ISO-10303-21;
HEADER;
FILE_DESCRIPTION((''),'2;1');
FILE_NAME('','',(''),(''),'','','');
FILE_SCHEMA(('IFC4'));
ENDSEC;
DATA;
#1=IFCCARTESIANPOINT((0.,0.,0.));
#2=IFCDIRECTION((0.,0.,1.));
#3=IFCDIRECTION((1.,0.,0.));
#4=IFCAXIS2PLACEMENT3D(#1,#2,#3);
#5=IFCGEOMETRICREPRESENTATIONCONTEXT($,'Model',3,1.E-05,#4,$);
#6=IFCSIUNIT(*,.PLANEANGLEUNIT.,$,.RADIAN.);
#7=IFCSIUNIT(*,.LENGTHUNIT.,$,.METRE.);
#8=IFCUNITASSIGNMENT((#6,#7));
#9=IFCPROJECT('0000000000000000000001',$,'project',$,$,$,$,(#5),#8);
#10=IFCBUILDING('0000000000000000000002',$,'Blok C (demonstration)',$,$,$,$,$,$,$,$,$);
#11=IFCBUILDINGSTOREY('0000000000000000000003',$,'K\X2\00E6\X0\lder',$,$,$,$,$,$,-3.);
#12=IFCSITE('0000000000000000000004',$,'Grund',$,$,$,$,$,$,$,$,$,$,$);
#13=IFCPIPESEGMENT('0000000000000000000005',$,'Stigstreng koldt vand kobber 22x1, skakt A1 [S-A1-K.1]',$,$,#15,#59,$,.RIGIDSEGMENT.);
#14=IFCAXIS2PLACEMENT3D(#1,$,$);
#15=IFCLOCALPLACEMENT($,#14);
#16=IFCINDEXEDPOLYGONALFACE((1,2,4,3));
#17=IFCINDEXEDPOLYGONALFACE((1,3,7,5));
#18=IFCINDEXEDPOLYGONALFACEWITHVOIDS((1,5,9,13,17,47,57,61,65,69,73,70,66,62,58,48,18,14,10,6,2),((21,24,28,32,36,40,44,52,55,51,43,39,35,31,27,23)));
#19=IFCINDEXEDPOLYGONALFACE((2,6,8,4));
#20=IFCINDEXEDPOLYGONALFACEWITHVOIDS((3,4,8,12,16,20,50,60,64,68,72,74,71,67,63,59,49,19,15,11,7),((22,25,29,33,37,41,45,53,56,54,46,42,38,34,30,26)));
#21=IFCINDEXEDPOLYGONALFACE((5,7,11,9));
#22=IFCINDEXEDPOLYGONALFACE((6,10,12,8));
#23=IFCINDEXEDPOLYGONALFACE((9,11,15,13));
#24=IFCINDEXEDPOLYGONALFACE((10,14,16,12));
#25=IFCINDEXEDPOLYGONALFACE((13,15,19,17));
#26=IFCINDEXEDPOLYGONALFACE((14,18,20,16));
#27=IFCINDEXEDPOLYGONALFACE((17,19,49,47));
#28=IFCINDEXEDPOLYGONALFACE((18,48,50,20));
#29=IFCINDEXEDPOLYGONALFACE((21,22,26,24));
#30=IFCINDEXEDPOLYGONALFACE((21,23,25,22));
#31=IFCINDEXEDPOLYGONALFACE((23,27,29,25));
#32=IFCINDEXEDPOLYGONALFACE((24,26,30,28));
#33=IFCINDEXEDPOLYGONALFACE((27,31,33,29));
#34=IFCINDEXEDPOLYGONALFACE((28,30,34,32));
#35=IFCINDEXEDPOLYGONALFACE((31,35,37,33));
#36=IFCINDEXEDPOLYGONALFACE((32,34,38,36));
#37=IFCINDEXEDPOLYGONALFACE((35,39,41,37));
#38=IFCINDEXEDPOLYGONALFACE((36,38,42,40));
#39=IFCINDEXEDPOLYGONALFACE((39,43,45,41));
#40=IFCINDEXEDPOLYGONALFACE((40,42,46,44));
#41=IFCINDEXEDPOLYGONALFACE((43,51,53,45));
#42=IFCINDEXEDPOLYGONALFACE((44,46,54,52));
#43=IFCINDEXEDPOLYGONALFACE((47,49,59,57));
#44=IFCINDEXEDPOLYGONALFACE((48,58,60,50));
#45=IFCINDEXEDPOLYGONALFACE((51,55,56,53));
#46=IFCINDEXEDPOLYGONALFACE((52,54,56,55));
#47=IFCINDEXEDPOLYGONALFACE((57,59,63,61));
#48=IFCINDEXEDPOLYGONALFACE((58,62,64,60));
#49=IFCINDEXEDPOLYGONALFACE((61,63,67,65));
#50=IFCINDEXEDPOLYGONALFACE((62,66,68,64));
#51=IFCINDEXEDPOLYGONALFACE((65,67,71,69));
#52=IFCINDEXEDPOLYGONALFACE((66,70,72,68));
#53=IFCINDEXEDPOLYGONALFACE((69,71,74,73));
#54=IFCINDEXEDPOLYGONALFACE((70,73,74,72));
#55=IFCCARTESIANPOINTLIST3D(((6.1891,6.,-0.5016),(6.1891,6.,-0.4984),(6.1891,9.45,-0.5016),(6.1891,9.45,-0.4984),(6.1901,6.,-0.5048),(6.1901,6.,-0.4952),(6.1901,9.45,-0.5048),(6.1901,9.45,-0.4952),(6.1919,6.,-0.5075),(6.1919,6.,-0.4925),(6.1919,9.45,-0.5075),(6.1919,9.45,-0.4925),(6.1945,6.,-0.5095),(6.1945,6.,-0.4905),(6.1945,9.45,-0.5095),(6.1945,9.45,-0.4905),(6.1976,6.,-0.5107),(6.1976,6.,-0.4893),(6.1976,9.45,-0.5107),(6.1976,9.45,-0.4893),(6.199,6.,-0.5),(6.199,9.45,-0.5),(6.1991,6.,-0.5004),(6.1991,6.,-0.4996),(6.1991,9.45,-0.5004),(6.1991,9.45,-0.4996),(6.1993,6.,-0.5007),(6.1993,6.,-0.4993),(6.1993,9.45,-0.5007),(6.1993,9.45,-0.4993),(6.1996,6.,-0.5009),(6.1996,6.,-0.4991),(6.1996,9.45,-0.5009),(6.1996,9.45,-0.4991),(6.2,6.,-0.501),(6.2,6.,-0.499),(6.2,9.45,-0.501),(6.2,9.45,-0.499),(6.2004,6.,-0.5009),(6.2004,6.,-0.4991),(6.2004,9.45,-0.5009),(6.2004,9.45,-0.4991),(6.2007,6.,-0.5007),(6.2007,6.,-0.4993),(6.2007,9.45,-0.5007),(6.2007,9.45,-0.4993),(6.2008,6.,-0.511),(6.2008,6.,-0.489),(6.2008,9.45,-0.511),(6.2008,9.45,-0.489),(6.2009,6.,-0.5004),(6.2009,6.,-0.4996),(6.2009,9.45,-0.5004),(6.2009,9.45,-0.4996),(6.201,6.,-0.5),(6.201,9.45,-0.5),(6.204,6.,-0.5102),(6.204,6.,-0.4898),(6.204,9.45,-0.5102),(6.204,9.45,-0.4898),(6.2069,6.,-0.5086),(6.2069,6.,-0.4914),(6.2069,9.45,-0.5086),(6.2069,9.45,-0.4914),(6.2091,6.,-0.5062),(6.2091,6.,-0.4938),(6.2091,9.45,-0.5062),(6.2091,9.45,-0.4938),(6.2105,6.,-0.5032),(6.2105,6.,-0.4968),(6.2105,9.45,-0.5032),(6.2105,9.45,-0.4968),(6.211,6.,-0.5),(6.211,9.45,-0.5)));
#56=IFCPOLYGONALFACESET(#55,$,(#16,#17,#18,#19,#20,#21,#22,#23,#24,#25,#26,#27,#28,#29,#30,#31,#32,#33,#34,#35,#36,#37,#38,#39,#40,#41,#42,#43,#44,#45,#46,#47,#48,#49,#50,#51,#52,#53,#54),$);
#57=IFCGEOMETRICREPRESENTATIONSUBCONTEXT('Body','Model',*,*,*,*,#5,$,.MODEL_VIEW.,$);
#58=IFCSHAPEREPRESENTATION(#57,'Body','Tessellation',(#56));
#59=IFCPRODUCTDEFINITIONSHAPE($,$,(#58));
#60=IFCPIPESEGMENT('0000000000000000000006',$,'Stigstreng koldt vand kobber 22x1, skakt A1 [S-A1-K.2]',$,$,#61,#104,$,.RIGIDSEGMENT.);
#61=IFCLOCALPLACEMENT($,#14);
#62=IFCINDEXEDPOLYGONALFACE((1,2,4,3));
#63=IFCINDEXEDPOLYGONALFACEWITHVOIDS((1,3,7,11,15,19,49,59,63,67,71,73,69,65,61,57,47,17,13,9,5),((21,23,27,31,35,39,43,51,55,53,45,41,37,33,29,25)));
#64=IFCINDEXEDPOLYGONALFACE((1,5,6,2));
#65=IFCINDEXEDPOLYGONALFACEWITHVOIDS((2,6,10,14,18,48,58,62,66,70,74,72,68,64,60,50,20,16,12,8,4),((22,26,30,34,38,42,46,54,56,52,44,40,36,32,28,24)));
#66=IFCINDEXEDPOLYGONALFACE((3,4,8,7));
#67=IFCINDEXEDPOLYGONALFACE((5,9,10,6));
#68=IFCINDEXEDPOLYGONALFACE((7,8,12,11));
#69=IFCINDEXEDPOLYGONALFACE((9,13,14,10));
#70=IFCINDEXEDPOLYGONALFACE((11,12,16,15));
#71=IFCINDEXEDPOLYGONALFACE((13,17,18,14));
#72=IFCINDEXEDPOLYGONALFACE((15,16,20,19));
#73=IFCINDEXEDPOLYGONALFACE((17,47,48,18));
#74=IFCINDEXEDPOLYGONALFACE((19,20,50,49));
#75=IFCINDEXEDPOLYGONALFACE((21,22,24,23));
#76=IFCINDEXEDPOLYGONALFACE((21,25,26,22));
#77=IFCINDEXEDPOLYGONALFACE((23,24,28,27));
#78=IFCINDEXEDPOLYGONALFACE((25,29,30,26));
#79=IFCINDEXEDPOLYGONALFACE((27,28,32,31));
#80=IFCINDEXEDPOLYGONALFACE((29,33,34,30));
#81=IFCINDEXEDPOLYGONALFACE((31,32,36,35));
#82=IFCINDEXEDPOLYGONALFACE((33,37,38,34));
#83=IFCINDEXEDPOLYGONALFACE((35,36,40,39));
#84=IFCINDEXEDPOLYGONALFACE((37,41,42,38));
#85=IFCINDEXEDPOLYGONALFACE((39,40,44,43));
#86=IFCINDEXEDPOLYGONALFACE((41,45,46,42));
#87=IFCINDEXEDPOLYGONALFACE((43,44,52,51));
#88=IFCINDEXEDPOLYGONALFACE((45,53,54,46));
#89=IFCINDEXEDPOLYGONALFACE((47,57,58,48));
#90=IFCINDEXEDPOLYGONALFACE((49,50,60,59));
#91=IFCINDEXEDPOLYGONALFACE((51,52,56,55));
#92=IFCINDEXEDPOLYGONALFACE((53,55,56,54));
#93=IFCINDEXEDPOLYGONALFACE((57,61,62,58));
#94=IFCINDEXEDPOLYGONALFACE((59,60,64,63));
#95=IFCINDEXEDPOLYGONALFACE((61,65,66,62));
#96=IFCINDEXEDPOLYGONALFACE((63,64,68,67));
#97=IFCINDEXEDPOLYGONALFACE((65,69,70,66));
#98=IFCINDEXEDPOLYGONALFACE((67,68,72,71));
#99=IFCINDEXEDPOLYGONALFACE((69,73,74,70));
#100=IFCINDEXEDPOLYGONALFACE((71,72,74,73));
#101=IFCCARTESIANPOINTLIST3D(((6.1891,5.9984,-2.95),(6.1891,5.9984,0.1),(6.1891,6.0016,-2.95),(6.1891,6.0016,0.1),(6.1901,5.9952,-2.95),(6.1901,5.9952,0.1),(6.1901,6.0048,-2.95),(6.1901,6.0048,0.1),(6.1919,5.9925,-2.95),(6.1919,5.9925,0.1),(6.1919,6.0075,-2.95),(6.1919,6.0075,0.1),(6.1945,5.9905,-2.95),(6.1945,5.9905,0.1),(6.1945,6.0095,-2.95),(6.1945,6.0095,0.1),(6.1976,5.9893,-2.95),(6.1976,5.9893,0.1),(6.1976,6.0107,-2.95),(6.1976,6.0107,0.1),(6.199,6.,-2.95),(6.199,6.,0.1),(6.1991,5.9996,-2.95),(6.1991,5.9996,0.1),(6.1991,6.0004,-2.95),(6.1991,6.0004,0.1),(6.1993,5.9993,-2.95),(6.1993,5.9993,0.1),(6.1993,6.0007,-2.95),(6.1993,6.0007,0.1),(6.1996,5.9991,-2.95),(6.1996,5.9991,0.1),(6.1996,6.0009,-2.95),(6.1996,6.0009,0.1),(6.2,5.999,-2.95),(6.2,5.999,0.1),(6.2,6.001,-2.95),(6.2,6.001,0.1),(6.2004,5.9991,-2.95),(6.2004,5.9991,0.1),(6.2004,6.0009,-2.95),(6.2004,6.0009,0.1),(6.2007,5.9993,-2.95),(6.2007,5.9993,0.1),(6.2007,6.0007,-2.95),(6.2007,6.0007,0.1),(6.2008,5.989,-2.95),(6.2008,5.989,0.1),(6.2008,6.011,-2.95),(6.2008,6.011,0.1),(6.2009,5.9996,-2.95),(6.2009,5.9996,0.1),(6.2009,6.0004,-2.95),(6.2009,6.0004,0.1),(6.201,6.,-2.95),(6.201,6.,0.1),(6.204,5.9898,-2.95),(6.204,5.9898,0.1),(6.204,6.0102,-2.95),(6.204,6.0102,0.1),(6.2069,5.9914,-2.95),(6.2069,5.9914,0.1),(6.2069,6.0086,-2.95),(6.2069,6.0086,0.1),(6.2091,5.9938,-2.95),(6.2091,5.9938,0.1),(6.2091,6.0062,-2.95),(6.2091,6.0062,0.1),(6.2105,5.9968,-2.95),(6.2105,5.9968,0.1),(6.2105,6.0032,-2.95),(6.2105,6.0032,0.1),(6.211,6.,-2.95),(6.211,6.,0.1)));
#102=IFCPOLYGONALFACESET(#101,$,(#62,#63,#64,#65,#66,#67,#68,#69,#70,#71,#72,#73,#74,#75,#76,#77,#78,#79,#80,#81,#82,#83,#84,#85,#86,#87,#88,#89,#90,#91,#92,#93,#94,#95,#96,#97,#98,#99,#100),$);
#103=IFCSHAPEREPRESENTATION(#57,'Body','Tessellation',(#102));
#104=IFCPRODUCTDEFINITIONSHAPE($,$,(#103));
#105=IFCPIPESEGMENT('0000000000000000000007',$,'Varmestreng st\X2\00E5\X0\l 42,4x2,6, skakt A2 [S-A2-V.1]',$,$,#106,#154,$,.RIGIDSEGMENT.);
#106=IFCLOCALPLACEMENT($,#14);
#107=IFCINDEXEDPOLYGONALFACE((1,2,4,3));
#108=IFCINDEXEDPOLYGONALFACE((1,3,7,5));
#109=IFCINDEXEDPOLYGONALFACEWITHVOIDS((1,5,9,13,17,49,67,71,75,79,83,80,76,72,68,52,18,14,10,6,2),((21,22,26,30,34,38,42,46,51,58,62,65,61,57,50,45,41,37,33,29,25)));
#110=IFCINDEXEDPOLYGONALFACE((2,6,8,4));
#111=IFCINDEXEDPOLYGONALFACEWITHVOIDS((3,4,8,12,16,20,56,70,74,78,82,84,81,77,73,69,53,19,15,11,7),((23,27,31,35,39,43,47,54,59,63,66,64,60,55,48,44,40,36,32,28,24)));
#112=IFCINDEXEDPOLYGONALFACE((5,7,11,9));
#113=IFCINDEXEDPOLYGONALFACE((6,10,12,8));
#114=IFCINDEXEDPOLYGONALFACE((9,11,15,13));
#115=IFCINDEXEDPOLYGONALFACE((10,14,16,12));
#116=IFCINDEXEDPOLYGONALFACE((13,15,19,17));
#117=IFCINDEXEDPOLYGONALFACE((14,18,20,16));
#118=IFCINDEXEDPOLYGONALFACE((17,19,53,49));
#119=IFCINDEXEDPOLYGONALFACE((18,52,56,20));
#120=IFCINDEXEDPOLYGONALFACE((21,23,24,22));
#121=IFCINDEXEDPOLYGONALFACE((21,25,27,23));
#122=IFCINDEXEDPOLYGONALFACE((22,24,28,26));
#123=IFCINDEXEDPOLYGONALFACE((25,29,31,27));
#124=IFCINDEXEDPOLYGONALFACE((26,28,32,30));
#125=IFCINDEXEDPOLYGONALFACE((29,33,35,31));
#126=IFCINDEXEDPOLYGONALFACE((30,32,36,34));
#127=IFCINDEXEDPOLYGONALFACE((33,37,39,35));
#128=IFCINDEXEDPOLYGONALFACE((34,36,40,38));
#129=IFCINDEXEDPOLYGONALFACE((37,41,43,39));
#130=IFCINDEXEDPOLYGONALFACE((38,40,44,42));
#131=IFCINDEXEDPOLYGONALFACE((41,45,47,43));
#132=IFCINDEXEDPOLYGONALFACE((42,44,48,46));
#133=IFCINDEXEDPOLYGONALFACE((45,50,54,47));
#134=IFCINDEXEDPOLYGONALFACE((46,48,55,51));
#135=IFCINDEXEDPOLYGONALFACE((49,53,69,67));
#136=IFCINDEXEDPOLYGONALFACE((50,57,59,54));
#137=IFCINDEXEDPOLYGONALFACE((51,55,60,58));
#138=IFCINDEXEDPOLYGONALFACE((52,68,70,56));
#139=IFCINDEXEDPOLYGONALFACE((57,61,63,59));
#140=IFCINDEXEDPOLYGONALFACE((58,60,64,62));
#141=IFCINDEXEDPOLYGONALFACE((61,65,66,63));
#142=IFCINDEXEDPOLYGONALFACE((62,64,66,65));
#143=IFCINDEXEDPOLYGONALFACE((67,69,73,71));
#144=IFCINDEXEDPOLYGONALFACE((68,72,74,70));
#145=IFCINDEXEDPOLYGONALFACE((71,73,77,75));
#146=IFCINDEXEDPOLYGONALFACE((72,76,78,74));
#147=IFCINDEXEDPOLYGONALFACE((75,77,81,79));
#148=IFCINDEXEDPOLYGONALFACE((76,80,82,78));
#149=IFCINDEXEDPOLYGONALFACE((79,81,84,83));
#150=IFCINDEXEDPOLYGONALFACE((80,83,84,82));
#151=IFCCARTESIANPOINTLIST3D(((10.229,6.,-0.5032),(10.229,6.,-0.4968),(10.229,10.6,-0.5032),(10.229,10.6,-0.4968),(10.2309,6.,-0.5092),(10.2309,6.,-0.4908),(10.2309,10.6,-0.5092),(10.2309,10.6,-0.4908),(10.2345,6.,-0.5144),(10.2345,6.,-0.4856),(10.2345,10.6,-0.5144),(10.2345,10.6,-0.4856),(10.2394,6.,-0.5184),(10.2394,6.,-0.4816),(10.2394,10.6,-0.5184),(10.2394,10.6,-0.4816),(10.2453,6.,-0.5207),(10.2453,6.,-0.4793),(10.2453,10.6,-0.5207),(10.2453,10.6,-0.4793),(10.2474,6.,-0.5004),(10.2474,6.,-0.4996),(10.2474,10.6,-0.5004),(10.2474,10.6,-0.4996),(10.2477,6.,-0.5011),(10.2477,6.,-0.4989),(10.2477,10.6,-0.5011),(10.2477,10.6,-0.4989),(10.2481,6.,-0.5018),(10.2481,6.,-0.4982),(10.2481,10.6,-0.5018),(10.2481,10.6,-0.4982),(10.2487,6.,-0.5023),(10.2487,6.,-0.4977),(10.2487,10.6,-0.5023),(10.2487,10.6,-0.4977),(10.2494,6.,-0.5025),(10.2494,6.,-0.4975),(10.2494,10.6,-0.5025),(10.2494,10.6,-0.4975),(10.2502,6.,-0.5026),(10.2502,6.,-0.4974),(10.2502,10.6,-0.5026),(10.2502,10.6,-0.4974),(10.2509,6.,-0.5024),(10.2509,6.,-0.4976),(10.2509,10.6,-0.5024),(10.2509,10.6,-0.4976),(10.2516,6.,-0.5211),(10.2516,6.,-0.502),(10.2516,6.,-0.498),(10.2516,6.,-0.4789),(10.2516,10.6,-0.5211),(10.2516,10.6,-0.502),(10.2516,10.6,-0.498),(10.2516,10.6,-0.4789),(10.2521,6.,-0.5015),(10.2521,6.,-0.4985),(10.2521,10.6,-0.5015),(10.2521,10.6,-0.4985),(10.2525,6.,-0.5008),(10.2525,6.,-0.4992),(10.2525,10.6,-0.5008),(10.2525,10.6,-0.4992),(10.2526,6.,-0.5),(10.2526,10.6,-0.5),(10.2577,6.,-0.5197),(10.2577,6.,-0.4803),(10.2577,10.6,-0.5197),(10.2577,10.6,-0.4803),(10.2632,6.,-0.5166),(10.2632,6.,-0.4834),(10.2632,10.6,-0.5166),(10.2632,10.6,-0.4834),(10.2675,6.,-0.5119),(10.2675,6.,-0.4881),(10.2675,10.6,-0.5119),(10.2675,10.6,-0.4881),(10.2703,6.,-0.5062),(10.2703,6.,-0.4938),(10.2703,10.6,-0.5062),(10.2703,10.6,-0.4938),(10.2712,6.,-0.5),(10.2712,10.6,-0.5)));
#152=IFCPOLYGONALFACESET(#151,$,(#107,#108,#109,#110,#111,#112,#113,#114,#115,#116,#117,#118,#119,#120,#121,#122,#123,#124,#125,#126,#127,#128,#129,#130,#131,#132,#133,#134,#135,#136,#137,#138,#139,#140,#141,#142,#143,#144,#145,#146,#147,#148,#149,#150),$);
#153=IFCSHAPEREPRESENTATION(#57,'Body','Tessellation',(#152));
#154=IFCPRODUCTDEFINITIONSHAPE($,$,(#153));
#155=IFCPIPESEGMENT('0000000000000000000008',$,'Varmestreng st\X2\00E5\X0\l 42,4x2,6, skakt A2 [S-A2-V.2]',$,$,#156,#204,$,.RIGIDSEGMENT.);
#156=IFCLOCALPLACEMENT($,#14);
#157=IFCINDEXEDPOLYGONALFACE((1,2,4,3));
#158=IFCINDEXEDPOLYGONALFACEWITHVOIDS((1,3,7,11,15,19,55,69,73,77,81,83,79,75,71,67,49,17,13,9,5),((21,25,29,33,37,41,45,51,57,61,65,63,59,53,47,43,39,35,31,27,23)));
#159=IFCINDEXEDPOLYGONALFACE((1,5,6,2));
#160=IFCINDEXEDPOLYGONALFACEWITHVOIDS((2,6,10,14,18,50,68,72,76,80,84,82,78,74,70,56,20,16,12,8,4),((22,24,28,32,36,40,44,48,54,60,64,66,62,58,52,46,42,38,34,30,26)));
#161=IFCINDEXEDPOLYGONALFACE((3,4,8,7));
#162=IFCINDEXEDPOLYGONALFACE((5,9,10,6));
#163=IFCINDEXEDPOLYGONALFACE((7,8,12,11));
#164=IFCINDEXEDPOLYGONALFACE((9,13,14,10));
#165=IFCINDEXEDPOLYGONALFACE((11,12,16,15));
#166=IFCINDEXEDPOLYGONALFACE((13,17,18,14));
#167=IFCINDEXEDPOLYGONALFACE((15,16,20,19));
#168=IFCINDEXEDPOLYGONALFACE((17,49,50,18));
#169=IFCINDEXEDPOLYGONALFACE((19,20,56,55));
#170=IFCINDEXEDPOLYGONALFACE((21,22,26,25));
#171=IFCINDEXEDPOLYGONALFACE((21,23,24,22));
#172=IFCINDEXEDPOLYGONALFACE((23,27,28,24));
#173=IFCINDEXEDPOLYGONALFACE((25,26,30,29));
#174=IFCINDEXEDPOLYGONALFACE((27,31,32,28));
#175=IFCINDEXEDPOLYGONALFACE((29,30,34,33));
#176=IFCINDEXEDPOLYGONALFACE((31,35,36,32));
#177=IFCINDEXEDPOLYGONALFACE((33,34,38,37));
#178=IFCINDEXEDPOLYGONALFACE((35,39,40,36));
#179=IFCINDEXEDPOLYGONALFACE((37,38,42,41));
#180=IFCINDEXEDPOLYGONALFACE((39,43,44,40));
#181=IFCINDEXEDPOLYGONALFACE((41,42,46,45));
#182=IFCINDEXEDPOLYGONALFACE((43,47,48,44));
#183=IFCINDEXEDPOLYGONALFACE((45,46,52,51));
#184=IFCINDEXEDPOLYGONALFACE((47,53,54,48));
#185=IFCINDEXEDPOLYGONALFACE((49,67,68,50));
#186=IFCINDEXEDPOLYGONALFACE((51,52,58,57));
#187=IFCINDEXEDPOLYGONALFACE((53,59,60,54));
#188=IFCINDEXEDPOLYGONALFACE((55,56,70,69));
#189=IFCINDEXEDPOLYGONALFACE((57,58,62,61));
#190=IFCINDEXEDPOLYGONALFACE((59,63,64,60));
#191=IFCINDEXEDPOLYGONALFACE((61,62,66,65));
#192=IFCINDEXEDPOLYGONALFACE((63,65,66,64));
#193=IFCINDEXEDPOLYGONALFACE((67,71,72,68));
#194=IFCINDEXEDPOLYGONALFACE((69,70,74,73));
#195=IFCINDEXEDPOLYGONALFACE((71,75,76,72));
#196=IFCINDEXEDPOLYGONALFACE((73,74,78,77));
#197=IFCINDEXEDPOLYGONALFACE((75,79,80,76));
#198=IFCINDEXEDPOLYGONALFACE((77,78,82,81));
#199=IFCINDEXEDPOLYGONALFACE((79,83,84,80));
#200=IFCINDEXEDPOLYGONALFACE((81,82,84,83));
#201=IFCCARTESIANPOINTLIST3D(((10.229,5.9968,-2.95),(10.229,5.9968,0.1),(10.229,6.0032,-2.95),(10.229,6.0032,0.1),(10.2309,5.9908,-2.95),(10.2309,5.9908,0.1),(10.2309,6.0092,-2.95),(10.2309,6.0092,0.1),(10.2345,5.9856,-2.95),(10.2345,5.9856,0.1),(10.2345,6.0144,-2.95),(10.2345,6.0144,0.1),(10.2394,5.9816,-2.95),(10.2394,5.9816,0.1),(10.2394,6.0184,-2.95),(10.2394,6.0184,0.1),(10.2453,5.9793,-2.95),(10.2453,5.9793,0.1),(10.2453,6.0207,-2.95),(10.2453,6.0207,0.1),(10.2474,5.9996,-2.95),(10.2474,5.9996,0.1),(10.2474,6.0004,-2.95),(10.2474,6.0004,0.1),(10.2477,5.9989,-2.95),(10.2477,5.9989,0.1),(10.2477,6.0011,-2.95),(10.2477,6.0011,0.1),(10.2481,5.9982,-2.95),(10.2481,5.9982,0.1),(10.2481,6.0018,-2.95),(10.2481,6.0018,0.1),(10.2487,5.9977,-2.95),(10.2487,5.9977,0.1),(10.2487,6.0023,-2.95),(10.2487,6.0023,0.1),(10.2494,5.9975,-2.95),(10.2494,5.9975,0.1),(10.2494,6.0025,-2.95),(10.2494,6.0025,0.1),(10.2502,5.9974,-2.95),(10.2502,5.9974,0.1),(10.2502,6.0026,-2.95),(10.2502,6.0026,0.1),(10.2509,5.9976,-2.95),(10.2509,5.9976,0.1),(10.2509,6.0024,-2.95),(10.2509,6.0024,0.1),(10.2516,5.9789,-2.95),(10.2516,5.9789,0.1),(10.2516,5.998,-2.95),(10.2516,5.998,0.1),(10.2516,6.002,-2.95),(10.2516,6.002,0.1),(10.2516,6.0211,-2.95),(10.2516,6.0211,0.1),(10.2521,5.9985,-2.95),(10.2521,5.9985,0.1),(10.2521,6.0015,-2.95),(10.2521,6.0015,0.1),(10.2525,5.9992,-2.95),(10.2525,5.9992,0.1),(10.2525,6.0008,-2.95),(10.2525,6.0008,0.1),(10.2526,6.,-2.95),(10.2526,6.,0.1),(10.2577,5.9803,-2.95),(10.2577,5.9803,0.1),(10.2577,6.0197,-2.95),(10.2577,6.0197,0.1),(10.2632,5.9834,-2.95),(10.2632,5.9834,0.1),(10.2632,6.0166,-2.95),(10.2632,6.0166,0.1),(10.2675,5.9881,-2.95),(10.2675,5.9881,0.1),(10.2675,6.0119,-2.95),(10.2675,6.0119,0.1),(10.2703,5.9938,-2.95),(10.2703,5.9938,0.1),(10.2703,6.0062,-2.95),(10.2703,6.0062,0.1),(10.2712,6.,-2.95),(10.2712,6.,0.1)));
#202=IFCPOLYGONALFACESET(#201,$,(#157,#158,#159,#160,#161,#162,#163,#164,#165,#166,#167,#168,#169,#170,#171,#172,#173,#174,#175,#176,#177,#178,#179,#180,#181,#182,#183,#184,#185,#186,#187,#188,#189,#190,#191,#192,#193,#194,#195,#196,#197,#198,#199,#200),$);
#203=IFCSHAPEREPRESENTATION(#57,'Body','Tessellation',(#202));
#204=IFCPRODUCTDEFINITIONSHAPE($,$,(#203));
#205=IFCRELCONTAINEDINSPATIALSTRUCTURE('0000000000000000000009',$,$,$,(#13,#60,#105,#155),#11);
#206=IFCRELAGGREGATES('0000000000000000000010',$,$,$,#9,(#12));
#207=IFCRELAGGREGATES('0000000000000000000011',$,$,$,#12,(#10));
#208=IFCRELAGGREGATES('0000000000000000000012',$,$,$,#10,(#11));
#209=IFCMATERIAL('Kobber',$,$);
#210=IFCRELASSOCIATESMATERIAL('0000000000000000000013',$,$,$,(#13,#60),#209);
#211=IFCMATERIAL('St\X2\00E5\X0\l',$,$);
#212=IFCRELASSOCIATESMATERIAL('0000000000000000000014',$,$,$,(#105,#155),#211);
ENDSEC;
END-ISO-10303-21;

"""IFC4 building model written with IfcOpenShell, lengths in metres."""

from ifc_helpers import new_model, si_unit, frame, origin_with_axes, place, context, subcontext, project, spatial, hollow_circle, extrude, material, element, save


model = new_model("IFC4")

# Units and contexts
model_context = context("Model", 3, precision=1e-05, world=origin_with_axes())
body_context = subcontext(model_context, "Body", "Model", "MODEL_VIEW")
ifc_project = project(units=[si_unit("PLANEANGLEUNIT", "RADIAN"), si_unit("LENGTHUNIT", "METRE")], contexts=[model_context])

# Site, building, storey
site = spatial("IfcSite", under=ifc_project, Name="Grund")
building = spatial("IfcBuilding", under=site, Name="Blok C (demonstration)")
storey = spatial("IfcBuildingStorey", under=building, Name="Kælder", Elevation=-3.0)

# Pipe segments
ifc_material_1 = material(Name="Stål")
ifc_material_2 = material(Name="Kobber")
pipe_segment_1_placement = place(None, origin_with_axes())
element("IfcPipeSegment", 1, at=pipe_segment_1_placement, inside=storey, material=ifc_material_2, Name="Stigstreng koldt vand kobber 22x1, skakt A1 [S-A1-K.1]", PredefinedType="RIGIDSEGMENT", context=body_context, shape_type="SweptSolid", body=[
    extrude(hollow_circle(Radius=0.011, WallThickness=0.01), frame((6.2, 9.45, -0.5), z_axis=(0.0, -1.0, 0.0), x_axis=(1.0, 0.0, 0.0)), (0.0, 0.0, 1.0), 3.45),
])
pipe_segment_2_placement = place(None, origin_with_axes())
element("IfcPipeSegment", 2, at=pipe_segment_2_placement, inside=storey, material=ifc_material_2, Name="Stigstreng koldt vand kobber 22x1, skakt A1 [S-A1-K.2]", PredefinedType="RIGIDSEGMENT", context=body_context, shape_type="SweptSolid", body=[
    extrude(hollow_circle(Radius=0.011, WallThickness=0.01), frame((6.2, 6.0, -2.95), z_axis=(0.0, 0.0, 1.0), x_axis=(1.0, 0.0, 0.0)), (0.0, 0.0, 1.0), 3.05),
])
pipe_segment_3_placement = place(None, origin_with_axes())
element("IfcPipeSegment", 3, at=pipe_segment_3_placement, inside=storey, material=ifc_material_1, Name="Varmestreng stål 42,4x2,6, skakt A2 [S-A2-V.1]", PredefinedType="RIGIDSEGMENT", context=body_context, shape_type="SweptSolid", body=[
    extrude(hollow_circle(Radius=0.0212, WallThickness=0.0186), frame((10.25, 10.6, -0.5), z_axis=(0.0, -1.0, 0.0), x_axis=(1.0, 0.0, 0.0)), (0.0, 0.0, 1.0), 4.6),
])
pipe_segment_4_placement = place(None, origin_with_axes())
element("IfcPipeSegment", 4, at=pipe_segment_4_placement, inside=storey, material=ifc_material_1, Name="Varmestreng stål 42,4x2,6, skakt A2 [S-A2-V.2]", PredefinedType="RIGIDSEGMENT", context=body_context, shape_type="SweptSolid", body=[
    extrude(hollow_circle(Radius=0.0212, WallThickness=0.0186), frame((10.25, 6.0, -2.95), z_axis=(0.0, 0.0, 1.0), x_axis=(1.0, 0.0, 0.0)), (0.0, 0.0, 1.0), 3.05),
])

save(model, "model.ifc")
